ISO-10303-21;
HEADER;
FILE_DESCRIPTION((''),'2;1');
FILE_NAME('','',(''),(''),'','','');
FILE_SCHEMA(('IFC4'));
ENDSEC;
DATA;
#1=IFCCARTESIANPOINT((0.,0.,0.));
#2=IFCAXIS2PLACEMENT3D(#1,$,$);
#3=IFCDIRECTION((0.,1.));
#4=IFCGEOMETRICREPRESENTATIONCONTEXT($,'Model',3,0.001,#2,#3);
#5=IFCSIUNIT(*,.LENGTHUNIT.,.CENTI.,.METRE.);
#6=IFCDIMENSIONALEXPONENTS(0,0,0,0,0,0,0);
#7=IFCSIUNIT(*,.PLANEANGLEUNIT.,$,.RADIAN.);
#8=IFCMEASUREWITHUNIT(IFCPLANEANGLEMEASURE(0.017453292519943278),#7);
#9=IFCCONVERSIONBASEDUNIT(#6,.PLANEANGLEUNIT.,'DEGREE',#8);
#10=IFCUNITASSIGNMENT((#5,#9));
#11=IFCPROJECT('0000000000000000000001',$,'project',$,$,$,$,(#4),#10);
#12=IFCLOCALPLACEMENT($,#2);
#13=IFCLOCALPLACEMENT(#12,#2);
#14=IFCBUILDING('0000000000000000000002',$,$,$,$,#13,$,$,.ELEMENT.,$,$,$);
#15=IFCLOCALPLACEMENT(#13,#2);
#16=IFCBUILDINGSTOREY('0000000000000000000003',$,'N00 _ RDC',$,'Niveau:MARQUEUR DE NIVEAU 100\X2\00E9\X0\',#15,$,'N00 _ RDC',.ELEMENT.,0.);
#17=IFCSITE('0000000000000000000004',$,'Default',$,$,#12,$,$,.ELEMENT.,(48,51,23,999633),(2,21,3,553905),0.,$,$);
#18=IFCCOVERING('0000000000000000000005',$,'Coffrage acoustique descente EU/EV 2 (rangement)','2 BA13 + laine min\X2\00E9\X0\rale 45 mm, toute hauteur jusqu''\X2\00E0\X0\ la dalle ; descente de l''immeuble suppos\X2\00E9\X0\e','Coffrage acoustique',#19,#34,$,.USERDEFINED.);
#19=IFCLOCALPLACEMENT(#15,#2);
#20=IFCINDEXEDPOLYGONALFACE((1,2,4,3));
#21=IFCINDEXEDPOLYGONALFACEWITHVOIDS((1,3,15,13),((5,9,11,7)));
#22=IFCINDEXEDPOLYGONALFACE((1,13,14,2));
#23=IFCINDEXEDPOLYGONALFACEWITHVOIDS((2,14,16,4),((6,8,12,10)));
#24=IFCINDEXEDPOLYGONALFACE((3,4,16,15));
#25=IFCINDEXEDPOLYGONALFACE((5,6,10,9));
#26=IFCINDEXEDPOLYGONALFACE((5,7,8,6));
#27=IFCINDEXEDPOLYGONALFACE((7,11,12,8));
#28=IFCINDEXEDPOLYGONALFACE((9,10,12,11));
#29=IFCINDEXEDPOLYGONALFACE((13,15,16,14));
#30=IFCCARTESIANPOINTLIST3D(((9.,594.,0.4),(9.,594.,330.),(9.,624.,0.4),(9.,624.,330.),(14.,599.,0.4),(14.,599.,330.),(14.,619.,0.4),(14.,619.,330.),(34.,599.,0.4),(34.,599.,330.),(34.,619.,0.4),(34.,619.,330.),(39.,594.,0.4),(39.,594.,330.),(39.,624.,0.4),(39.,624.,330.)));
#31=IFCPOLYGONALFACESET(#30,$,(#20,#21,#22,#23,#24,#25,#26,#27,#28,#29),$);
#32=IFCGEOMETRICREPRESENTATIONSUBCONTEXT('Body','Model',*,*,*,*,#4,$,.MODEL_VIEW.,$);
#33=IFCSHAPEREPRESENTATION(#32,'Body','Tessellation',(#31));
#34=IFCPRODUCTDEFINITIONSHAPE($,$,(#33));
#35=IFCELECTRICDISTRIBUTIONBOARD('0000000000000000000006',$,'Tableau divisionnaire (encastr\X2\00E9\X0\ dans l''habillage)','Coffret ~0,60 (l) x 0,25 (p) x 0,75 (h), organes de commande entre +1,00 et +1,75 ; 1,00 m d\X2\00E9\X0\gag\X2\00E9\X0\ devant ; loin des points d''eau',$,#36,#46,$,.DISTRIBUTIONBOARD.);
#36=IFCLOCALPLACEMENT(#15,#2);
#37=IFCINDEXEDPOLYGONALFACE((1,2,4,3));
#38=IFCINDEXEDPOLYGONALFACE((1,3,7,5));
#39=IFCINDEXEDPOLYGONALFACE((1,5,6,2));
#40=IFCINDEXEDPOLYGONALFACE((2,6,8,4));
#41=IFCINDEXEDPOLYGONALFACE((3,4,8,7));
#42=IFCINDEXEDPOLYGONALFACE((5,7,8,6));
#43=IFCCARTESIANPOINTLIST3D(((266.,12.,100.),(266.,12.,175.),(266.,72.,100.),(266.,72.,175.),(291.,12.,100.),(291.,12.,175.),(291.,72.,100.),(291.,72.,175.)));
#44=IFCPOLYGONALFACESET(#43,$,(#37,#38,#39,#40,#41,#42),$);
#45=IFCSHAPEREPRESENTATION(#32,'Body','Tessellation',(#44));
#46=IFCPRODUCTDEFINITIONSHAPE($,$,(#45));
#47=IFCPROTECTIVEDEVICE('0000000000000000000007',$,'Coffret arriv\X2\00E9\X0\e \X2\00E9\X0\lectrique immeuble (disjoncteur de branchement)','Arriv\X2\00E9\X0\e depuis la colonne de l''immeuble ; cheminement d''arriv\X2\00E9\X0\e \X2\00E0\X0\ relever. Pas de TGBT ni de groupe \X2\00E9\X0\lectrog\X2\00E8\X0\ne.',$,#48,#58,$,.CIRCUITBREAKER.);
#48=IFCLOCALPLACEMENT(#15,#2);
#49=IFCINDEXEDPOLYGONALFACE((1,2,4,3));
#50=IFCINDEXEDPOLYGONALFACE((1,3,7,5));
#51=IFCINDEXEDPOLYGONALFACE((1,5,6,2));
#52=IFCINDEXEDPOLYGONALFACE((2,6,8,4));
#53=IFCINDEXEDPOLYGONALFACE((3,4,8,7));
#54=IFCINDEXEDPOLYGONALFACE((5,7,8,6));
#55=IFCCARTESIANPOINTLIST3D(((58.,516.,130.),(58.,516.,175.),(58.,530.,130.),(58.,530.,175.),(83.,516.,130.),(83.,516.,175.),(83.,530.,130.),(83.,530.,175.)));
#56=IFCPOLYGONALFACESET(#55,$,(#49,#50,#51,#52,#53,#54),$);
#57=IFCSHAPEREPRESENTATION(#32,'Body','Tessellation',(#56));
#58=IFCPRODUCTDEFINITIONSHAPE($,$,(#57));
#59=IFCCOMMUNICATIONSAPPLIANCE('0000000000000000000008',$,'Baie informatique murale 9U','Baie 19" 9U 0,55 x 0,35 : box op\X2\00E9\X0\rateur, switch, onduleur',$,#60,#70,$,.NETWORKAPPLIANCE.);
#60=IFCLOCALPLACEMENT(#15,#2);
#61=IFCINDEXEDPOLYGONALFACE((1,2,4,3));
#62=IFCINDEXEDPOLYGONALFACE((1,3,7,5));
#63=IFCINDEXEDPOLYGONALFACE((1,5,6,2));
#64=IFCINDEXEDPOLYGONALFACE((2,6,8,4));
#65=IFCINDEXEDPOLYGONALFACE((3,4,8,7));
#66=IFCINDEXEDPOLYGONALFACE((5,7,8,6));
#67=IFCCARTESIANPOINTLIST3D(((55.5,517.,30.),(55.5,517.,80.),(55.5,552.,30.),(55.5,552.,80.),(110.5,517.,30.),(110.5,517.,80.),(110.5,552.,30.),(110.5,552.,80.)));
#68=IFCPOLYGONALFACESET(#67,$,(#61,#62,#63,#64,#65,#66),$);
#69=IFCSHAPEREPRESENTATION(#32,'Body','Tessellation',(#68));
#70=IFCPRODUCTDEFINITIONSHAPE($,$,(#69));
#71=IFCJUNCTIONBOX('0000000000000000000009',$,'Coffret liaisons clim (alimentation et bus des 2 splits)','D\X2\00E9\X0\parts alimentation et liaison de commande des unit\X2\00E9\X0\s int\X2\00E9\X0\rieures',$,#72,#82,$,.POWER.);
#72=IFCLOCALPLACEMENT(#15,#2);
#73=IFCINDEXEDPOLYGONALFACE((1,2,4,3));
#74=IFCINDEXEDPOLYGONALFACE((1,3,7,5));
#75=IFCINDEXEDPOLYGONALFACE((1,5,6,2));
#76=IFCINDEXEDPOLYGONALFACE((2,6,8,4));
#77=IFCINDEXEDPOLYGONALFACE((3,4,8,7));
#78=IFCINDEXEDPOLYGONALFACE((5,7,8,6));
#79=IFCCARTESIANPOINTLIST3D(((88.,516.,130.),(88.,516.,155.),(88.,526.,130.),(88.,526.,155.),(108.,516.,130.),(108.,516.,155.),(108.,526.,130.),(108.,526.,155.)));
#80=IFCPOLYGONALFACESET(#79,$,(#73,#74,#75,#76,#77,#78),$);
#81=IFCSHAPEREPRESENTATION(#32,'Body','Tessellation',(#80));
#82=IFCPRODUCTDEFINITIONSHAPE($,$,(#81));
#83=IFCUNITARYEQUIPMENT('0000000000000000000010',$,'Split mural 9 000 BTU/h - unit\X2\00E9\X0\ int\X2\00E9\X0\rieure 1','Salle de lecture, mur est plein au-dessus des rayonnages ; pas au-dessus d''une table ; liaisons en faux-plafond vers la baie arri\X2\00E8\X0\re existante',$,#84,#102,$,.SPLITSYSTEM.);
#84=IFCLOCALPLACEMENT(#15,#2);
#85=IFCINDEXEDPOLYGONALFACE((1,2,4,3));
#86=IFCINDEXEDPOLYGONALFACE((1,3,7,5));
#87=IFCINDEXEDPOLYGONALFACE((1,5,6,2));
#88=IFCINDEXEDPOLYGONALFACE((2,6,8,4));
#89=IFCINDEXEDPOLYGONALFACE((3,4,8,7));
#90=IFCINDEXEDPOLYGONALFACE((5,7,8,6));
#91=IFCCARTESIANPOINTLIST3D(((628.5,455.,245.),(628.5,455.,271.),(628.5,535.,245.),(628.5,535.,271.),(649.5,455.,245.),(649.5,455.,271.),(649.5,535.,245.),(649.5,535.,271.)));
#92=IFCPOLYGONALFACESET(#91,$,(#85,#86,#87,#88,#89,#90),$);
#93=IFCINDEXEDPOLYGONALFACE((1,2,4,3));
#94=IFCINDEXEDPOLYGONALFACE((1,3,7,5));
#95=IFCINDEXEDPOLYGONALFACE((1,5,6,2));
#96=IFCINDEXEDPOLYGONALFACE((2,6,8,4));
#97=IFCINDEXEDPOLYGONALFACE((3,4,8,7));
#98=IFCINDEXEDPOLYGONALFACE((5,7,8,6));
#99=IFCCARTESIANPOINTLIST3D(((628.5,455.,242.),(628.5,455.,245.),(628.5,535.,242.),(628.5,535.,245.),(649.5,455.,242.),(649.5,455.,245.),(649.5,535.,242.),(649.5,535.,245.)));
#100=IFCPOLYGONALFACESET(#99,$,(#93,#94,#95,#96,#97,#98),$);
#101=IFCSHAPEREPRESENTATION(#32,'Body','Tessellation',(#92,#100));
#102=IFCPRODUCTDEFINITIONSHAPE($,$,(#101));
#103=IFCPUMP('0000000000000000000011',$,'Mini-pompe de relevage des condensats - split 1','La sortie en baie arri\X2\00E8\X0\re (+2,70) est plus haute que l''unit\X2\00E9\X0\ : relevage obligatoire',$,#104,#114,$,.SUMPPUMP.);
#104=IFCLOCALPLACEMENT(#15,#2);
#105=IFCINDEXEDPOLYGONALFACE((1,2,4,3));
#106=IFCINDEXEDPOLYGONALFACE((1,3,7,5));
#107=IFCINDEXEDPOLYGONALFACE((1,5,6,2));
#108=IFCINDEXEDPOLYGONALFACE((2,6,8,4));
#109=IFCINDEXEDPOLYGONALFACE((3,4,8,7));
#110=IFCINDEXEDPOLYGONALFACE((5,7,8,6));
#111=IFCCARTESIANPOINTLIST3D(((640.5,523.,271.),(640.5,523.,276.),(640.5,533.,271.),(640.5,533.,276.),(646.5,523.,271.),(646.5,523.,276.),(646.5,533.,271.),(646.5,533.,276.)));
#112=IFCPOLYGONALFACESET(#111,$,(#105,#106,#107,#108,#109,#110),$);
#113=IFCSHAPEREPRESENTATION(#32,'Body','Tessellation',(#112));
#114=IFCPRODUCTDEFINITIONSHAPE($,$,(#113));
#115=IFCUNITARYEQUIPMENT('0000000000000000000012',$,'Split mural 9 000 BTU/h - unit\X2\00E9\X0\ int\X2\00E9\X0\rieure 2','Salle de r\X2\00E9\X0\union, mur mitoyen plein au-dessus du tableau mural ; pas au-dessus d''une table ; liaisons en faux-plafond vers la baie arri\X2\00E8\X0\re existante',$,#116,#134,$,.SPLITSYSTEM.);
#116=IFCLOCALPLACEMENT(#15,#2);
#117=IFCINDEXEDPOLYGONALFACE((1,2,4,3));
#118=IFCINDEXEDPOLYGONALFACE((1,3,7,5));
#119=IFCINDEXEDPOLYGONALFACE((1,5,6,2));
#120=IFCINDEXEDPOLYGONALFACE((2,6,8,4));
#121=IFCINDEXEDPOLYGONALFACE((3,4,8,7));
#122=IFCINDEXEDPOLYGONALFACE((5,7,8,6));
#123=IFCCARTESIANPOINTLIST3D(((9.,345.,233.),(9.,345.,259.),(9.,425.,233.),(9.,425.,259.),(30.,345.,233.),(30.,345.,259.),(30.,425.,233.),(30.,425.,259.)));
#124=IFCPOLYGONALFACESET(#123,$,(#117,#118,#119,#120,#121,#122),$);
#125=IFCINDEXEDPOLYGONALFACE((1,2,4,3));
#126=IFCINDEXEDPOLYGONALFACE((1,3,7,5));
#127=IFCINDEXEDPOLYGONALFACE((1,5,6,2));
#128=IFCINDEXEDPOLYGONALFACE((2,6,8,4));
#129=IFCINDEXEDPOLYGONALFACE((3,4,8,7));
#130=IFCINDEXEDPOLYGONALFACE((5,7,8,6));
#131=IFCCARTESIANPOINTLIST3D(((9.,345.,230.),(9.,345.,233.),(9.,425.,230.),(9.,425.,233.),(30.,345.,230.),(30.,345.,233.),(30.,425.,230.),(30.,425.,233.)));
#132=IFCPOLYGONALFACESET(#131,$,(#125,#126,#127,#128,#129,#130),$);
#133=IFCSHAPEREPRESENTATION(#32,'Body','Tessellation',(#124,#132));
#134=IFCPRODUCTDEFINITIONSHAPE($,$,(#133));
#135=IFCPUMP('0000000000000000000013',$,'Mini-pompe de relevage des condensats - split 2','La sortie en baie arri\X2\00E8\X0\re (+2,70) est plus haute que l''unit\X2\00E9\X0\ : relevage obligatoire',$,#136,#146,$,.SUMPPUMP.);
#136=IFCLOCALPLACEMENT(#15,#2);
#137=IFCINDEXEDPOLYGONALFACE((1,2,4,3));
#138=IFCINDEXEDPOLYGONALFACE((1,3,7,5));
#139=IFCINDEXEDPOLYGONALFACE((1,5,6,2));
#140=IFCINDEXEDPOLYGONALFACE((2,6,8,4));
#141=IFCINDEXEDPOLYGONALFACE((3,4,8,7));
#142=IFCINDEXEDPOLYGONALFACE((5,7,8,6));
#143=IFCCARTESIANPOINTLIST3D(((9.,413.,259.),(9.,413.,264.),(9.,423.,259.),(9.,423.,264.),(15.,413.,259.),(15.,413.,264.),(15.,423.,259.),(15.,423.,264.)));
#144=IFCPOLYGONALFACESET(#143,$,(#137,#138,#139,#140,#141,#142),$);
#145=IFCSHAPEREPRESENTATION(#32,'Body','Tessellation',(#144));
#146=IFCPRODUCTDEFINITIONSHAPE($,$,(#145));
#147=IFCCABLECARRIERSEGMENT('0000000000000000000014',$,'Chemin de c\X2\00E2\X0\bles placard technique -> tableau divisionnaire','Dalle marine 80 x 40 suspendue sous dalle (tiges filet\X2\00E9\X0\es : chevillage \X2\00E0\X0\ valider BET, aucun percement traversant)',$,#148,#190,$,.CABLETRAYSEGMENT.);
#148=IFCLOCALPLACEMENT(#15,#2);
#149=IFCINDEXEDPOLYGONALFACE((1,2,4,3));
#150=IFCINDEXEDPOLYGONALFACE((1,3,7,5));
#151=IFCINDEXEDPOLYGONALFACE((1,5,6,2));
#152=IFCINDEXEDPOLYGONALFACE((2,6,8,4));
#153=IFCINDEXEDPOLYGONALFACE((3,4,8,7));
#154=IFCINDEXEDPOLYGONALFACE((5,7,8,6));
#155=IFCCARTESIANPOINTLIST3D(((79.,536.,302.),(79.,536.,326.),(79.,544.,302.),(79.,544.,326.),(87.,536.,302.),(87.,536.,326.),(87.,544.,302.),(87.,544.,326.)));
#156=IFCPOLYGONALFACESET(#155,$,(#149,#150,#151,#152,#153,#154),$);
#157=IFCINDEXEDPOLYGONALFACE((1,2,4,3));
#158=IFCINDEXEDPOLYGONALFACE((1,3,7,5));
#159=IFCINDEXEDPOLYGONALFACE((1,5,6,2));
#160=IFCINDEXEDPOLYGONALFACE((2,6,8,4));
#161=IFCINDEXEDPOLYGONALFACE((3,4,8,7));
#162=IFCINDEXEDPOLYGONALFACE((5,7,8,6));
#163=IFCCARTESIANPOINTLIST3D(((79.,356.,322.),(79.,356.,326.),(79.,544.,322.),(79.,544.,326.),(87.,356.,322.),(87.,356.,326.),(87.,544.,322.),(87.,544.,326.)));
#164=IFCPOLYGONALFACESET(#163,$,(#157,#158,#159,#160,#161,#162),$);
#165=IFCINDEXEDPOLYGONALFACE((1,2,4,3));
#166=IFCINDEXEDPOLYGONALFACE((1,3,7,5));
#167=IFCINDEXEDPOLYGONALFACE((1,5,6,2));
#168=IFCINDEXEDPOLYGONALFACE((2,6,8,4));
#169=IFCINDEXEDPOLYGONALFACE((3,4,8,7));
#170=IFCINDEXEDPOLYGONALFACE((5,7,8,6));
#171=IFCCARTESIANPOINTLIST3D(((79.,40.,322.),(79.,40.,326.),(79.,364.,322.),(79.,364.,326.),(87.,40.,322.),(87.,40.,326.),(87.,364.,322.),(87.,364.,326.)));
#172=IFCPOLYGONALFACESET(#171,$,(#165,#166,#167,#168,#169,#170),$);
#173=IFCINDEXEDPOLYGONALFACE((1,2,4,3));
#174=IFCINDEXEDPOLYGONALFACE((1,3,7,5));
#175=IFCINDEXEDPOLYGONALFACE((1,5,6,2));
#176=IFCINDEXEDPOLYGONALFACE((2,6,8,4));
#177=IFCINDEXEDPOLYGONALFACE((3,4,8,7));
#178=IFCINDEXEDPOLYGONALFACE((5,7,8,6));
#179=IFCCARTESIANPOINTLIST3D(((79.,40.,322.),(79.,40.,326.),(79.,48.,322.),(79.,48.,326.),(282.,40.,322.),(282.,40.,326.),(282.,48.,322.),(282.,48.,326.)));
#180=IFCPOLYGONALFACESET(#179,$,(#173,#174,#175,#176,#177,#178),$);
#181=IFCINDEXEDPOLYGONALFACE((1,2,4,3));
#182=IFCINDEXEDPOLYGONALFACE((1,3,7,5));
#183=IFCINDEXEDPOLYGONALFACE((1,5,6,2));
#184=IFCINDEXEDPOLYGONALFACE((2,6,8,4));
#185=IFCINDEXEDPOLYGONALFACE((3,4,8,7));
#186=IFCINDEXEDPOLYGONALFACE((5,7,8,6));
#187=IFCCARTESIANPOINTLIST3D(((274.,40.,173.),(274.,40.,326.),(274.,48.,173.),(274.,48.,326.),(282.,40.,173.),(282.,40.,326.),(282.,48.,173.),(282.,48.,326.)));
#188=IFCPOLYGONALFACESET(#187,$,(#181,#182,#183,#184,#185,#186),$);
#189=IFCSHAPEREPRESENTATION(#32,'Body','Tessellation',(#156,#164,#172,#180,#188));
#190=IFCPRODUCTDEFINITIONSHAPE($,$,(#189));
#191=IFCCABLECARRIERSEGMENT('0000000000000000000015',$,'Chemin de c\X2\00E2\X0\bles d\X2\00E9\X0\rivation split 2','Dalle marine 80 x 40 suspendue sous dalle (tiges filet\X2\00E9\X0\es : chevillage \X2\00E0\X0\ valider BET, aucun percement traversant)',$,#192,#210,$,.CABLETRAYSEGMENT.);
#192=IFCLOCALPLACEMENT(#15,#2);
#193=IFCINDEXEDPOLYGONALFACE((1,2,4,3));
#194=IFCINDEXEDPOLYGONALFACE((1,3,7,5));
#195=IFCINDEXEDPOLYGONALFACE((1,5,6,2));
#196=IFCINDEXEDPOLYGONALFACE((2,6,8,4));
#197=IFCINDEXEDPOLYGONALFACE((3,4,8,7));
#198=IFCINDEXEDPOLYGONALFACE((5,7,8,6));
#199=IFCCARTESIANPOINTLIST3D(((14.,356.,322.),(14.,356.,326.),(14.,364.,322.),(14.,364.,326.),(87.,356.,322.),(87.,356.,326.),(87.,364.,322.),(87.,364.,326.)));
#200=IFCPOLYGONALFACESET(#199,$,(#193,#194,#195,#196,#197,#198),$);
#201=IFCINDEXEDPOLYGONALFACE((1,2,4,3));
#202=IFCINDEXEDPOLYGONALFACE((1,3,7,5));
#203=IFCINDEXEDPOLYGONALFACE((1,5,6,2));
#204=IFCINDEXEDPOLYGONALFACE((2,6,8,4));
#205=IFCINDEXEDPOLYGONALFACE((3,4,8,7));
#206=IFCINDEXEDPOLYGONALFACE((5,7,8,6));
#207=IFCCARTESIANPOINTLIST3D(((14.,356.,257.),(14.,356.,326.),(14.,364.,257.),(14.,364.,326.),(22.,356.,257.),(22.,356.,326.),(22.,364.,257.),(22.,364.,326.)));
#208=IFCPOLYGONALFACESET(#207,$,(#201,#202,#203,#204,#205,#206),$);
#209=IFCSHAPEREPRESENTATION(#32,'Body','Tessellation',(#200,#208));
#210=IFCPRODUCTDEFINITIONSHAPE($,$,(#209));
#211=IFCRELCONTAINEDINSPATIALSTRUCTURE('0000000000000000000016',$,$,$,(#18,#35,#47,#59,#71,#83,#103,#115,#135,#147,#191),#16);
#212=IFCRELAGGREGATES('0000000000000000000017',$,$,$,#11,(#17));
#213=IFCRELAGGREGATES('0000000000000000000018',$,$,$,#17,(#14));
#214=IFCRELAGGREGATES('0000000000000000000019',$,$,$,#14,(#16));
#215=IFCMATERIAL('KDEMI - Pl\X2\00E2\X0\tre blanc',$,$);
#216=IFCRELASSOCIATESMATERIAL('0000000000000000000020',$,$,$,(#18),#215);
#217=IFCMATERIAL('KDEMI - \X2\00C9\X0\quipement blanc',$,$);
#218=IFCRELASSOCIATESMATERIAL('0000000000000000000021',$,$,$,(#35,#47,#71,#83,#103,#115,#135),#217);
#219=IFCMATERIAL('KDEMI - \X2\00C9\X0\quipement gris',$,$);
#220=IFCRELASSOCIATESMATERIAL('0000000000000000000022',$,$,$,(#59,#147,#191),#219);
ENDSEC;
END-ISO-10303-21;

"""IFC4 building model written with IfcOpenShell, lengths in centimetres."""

from ifc_helpers import new_model, entity, si_unit, converted_unit, direction, frame, frame_2d, origin, origin_with_axes, place, context, subcontext, project, spatial, rectangle, hollow_rectangle, extrude, material, element, save


model = new_model("IFC4")

# Units and contexts
model_context = context("Model", 3, precision=0.001, world=origin(), true_north=direction((0.0, 1.0)))
body_context = subcontext(model_context, "Body", "Model", "MODEL_VIEW")
ifc_project = project(units=[si_unit("LENGTHUNIT", "METRE", prefix="CENTI"), converted_unit("PLANEANGLEUNIT", "DEGREE", entity("IfcPlaneAngleMeasure", 0.017453292519943278), si_unit("PLANEANGLEUNIT", "RADIAN"), dimensions=[0, 0, 0, 0, 0, 0, 0])], contexts=[model_context])

# Site, building, storey
site_placement = place(None, origin())
site = spatial("IfcSite", under=ifc_project, at=site_placement, Name="Default", CompositionType="ELEMENT", RefLatitude=(48, 51, 23, 999633), RefLongitude=(2, 21, 3, 553905), RefElevation=0.0)
building_placement = place(site_placement, origin())
building = spatial("IfcBuilding", under=site, at=building_placement, CompositionType="ELEMENT")
storey_placement = place(building_placement, origin())
storey = spatial("IfcBuildingStorey", under=building, at=storey_placement, Name="N00 _ RDC", ObjectType="Niveau:MARQUEUR DE NIVEAU 100é", LongName="N00 _ RDC", CompositionType="ELEMENT", Elevation=0.0)

# Covering
ifc_material_1 = material(Name="KDEMI - Plâtre blanc")
covering_1_placement = place(storey_placement, origin_with_axes())
element("IfcCovering", 1, at=covering_1_placement, inside=storey, material=ifc_material_1, Name="Coffrage acoustique descente EU/EV 2 (rangement)", Description="2 BA13 + laine minérale 45 mm, toute hauteur jusqu'à la dalle ; descente de l'immeuble supposée", ObjectType="Coffrage acoustique", PredefinedType="USERDEFINED", context=body_context, shape_type="SweptSolid", body=[
    extrude(hollow_rectangle(XDim=30.0, YDim=30.0, WallThickness=5.0, at=frame_2d((24.0, 609.0))), frame((0.0, 0.0, 0.4)), (0.0, 0.0, 1.0), 329.6),
])

# Electric distribution board
ifc_material_2 = material(Name="KDEMI - Équipement blanc")
electric_distribution_board_placement = place(storey_placement, origin_with_axes())
element("IfcElectricDistributionBoard", 2, at=electric_distribution_board_placement, inside=storey, material=ifc_material_2, Name="Tableau divisionnaire (encastré dans l'habillage)", Description="Coffret ~0,60 (l) x 0,25 (p) x 0,75 (h), organes de commande entre +1,00 et +1,75 ; 1,00 m dégagé devant ; loin des points d'eau", PredefinedType="DISTRIBUTIONBOARD", context=body_context, shape_type="SweptSolid", body=[
    extrude(rectangle(XDim=25.0, YDim=60.0, at=frame_2d((278.5, 42.0))), frame((0.0, 0.0, 100.0)), (0.0, 0.0, 1.0), 75.0),
])

# Protective device
protective_device_placement = place(storey_placement, origin_with_axes())
element("IfcProtectiveDevice", 3, at=protective_device_placement, inside=storey, material=ifc_material_2, Name="Coffret arrivée électrique immeuble (disjoncteur de branchement)", Description="Arrivée depuis la colonne de l'immeuble ; cheminement d'arrivée à relever. Pas de TGBT ni de groupe électrogène.", PredefinedType="CIRCUITBREAKER", context=body_context, shape_type="SweptSolid", body=[
    extrude(rectangle(XDim=25.0, YDim=14.0, at=frame_2d((70.5, 523.0))), frame((0.0, 0.0, 130.0)), (0.0, 0.0, 1.0), 45.0),
])

# Communications appliance
ifc_material_3 = material(Name="KDEMI - Équipement gris")
communications_appliance_placement = place(storey_placement, origin_with_axes())
element("IfcCommunicationsAppliance", 4, at=communications_appliance_placement, inside=storey, material=ifc_material_3, Name="Baie informatique murale 9U", Description="Baie 19\" 9U 0,55 x 0,35 : box opérateur, switch, onduleur", PredefinedType="NETWORKAPPLIANCE", context=body_context, shape_type="SweptSolid", body=[
    extrude(rectangle(XDim=55.0, YDim=35.0, at=frame_2d((83.0, 534.5))), frame((0.0, 0.0, 30.0)), (0.0, 0.0, 1.0), 50.0),
])

# Junction box
junction_box_placement = place(storey_placement, origin_with_axes())
element("IfcJunctionBox", 5, at=junction_box_placement, inside=storey, material=ifc_material_2, Name="Coffret liaisons clim (alimentation et bus des 2 splits)", Description="Départs alimentation et liaison de commande des unités intérieures", PredefinedType="POWER", context=body_context, shape_type="SweptSolid", body=[
    extrude(rectangle(XDim=20.0, YDim=10.0, at=frame_2d((98.0, 521.0))), frame((0.0, 0.0, 130.0)), (0.0, 0.0, 1.0), 25.0),
])

# Unitary equipment
unitary_equipment_1_placement = place(storey_placement, origin_with_axes())
element("IfcUnitaryEquipment", 6, at=unitary_equipment_1_placement, inside=storey, material=ifc_material_2, Name="Split mural 9 000 BTU/h - unité intérieure 1", Description="Salle de lecture, mur est plein au-dessus des rayonnages ; pas au-dessus d'une table ; liaisons en faux-plafond vers la baie arrière existante", PredefinedType="SPLITSYSTEM", context=body_context, shape_type="SweptSolid", body=[
    extrude(rectangle(XDim=21.0, YDim=80.0, at=frame_2d((639.0, 495.0))), frame((0.0, 0.0, 245.0)), (0.0, 0.0, 1.0), 26.0),
    extrude(rectangle(XDim=21.0, YDim=80.0, at=frame_2d((639.0, 495.0))), frame((0.0, 0.0, 242.0)), (0.0, 0.0, 1.0), 3.0),
])

# Pump
pump_1_placement = place(storey_placement, origin_with_axes())
element("IfcPump", 7, at=pump_1_placement, inside=storey, material=ifc_material_2, Name="Mini-pompe de relevage des condensats - split 1", Description="La sortie en baie arrière (+2,70) est plus haute que l'unité : relevage obligatoire", PredefinedType="SUMPPUMP", context=body_context, shape_type="SweptSolid", body=[
    extrude(rectangle(XDim=6.0, YDim=10.0, at=frame_2d((643.5, 528.0))), frame((0.0, 0.0, 271.0)), (0.0, 0.0, 1.0), 5.0),
])

# Unitary equipment
unitary_equipment_2_placement = place(storey_placement, origin_with_axes())
element("IfcUnitaryEquipment", 8, at=unitary_equipment_2_placement, inside=storey, material=ifc_material_2, Name="Split mural 9 000 BTU/h - unité intérieure 2", Description="Salle de réunion, mur mitoyen plein au-dessus du tableau mural ; pas au-dessus d'une table ; liaisons en faux-plafond vers la baie arrière existante", PredefinedType="SPLITSYSTEM", context=body_context, shape_type="SweptSolid", body=[
    extrude(rectangle(XDim=21.0, YDim=80.0, at=frame_2d((19.5, 385.0))), frame((0.0, 0.0, 233.0)), (0.0, 0.0, 1.0), 26.0),
    extrude(rectangle(XDim=21.0, YDim=80.0, at=frame_2d((19.5, 385.0))), frame((0.0, 0.0, 230.0)), (0.0, 0.0, 1.0), 3.0),
])

# Pump
pump_2_placement = place(storey_placement, origin_with_axes())
element("IfcPump", 9, at=pump_2_placement, inside=storey, material=ifc_material_2, Name="Mini-pompe de relevage des condensats - split 2", Description="La sortie en baie arrière (+2,70) est plus haute que l'unité : relevage obligatoire", PredefinedType="SUMPPUMP", context=body_context, shape_type="SweptSolid", body=[
    extrude(rectangle(XDim=6.0, YDim=10.0, at=frame_2d((12.0, 418.0))), frame((0.0, 0.0, 259.0)), (0.0, 0.0, 1.0), 5.0),
])

# Cable carrier segments
cable_carrier_segment_1_placement = place(storey_placement, origin_with_axes())
element("IfcCableCarrierSegment", 10, at=cable_carrier_segment_1_placement, inside=storey, material=ifc_material_3, Name="Chemin de câbles placard technique -> tableau divisionnaire", Description="Dalle marine 80 x 40 suspendue sous dalle (tiges filetées : chevillage à valider BET, aucun percement traversant)", PredefinedType="CABLETRAYSEGMENT", context=body_context, shape_type="SweptSolid", body=[
    extrude(rectangle(XDim=8.0, YDim=8.0, at=frame_2d((83.0, 540.0))), frame((0.0, 0.0, 302.0)), (0.0, 0.0, 1.0), 24.0),
    extrude(rectangle(XDim=8.0, YDim=188.0, at=frame_2d((83.0, 450.0))), frame((0.0, 0.0, 322.0)), (0.0, 0.0, 1.0), 4.0),
    extrude(rectangle(XDim=8.0, YDim=324.0, at=frame_2d((83.0, 202.0))), frame((0.0, 0.0, 322.0)), (0.0, 0.0, 1.0), 4.0),
    extrude(rectangle(XDim=203.0, YDim=8.0, at=frame_2d((180.5, 44.0))), frame((0.0, 0.0, 322.0)), (0.0, 0.0, 1.0), 4.0),
    extrude(rectangle(XDim=8.0, YDim=8.0, at=frame_2d((278.0, 44.0))), frame((0.0, 0.0, 173.0)), (0.0, 0.0, 1.0), 153.0),
])
cable_carrier_segment_2_placement = place(storey_placement, origin_with_axes())
element("IfcCableCarrierSegment", 11, at=cable_carrier_segment_2_placement, inside=storey, material=ifc_material_3, Name="Chemin de câbles dérivation split 2", Description="Dalle marine 80 x 40 suspendue sous dalle (tiges filetées : chevillage à valider BET, aucun percement traversant)", PredefinedType="CABLETRAYSEGMENT", context=body_context, shape_type="SweptSolid", body=[
    extrude(rectangle(XDim=73.0, YDim=8.0, at=frame_2d((50.5, 360.0))), frame((0.0, 0.0, 322.0)), (0.0, 0.0, 1.0), 4.0),
    extrude(rectangle(XDim=8.0, YDim=8.0, at=frame_2d((18.0, 360.0))), frame((0.0, 0.0, 257.0)), (0.0, 0.0, 1.0), 69.0),
])

save(model, "model.ifc")
